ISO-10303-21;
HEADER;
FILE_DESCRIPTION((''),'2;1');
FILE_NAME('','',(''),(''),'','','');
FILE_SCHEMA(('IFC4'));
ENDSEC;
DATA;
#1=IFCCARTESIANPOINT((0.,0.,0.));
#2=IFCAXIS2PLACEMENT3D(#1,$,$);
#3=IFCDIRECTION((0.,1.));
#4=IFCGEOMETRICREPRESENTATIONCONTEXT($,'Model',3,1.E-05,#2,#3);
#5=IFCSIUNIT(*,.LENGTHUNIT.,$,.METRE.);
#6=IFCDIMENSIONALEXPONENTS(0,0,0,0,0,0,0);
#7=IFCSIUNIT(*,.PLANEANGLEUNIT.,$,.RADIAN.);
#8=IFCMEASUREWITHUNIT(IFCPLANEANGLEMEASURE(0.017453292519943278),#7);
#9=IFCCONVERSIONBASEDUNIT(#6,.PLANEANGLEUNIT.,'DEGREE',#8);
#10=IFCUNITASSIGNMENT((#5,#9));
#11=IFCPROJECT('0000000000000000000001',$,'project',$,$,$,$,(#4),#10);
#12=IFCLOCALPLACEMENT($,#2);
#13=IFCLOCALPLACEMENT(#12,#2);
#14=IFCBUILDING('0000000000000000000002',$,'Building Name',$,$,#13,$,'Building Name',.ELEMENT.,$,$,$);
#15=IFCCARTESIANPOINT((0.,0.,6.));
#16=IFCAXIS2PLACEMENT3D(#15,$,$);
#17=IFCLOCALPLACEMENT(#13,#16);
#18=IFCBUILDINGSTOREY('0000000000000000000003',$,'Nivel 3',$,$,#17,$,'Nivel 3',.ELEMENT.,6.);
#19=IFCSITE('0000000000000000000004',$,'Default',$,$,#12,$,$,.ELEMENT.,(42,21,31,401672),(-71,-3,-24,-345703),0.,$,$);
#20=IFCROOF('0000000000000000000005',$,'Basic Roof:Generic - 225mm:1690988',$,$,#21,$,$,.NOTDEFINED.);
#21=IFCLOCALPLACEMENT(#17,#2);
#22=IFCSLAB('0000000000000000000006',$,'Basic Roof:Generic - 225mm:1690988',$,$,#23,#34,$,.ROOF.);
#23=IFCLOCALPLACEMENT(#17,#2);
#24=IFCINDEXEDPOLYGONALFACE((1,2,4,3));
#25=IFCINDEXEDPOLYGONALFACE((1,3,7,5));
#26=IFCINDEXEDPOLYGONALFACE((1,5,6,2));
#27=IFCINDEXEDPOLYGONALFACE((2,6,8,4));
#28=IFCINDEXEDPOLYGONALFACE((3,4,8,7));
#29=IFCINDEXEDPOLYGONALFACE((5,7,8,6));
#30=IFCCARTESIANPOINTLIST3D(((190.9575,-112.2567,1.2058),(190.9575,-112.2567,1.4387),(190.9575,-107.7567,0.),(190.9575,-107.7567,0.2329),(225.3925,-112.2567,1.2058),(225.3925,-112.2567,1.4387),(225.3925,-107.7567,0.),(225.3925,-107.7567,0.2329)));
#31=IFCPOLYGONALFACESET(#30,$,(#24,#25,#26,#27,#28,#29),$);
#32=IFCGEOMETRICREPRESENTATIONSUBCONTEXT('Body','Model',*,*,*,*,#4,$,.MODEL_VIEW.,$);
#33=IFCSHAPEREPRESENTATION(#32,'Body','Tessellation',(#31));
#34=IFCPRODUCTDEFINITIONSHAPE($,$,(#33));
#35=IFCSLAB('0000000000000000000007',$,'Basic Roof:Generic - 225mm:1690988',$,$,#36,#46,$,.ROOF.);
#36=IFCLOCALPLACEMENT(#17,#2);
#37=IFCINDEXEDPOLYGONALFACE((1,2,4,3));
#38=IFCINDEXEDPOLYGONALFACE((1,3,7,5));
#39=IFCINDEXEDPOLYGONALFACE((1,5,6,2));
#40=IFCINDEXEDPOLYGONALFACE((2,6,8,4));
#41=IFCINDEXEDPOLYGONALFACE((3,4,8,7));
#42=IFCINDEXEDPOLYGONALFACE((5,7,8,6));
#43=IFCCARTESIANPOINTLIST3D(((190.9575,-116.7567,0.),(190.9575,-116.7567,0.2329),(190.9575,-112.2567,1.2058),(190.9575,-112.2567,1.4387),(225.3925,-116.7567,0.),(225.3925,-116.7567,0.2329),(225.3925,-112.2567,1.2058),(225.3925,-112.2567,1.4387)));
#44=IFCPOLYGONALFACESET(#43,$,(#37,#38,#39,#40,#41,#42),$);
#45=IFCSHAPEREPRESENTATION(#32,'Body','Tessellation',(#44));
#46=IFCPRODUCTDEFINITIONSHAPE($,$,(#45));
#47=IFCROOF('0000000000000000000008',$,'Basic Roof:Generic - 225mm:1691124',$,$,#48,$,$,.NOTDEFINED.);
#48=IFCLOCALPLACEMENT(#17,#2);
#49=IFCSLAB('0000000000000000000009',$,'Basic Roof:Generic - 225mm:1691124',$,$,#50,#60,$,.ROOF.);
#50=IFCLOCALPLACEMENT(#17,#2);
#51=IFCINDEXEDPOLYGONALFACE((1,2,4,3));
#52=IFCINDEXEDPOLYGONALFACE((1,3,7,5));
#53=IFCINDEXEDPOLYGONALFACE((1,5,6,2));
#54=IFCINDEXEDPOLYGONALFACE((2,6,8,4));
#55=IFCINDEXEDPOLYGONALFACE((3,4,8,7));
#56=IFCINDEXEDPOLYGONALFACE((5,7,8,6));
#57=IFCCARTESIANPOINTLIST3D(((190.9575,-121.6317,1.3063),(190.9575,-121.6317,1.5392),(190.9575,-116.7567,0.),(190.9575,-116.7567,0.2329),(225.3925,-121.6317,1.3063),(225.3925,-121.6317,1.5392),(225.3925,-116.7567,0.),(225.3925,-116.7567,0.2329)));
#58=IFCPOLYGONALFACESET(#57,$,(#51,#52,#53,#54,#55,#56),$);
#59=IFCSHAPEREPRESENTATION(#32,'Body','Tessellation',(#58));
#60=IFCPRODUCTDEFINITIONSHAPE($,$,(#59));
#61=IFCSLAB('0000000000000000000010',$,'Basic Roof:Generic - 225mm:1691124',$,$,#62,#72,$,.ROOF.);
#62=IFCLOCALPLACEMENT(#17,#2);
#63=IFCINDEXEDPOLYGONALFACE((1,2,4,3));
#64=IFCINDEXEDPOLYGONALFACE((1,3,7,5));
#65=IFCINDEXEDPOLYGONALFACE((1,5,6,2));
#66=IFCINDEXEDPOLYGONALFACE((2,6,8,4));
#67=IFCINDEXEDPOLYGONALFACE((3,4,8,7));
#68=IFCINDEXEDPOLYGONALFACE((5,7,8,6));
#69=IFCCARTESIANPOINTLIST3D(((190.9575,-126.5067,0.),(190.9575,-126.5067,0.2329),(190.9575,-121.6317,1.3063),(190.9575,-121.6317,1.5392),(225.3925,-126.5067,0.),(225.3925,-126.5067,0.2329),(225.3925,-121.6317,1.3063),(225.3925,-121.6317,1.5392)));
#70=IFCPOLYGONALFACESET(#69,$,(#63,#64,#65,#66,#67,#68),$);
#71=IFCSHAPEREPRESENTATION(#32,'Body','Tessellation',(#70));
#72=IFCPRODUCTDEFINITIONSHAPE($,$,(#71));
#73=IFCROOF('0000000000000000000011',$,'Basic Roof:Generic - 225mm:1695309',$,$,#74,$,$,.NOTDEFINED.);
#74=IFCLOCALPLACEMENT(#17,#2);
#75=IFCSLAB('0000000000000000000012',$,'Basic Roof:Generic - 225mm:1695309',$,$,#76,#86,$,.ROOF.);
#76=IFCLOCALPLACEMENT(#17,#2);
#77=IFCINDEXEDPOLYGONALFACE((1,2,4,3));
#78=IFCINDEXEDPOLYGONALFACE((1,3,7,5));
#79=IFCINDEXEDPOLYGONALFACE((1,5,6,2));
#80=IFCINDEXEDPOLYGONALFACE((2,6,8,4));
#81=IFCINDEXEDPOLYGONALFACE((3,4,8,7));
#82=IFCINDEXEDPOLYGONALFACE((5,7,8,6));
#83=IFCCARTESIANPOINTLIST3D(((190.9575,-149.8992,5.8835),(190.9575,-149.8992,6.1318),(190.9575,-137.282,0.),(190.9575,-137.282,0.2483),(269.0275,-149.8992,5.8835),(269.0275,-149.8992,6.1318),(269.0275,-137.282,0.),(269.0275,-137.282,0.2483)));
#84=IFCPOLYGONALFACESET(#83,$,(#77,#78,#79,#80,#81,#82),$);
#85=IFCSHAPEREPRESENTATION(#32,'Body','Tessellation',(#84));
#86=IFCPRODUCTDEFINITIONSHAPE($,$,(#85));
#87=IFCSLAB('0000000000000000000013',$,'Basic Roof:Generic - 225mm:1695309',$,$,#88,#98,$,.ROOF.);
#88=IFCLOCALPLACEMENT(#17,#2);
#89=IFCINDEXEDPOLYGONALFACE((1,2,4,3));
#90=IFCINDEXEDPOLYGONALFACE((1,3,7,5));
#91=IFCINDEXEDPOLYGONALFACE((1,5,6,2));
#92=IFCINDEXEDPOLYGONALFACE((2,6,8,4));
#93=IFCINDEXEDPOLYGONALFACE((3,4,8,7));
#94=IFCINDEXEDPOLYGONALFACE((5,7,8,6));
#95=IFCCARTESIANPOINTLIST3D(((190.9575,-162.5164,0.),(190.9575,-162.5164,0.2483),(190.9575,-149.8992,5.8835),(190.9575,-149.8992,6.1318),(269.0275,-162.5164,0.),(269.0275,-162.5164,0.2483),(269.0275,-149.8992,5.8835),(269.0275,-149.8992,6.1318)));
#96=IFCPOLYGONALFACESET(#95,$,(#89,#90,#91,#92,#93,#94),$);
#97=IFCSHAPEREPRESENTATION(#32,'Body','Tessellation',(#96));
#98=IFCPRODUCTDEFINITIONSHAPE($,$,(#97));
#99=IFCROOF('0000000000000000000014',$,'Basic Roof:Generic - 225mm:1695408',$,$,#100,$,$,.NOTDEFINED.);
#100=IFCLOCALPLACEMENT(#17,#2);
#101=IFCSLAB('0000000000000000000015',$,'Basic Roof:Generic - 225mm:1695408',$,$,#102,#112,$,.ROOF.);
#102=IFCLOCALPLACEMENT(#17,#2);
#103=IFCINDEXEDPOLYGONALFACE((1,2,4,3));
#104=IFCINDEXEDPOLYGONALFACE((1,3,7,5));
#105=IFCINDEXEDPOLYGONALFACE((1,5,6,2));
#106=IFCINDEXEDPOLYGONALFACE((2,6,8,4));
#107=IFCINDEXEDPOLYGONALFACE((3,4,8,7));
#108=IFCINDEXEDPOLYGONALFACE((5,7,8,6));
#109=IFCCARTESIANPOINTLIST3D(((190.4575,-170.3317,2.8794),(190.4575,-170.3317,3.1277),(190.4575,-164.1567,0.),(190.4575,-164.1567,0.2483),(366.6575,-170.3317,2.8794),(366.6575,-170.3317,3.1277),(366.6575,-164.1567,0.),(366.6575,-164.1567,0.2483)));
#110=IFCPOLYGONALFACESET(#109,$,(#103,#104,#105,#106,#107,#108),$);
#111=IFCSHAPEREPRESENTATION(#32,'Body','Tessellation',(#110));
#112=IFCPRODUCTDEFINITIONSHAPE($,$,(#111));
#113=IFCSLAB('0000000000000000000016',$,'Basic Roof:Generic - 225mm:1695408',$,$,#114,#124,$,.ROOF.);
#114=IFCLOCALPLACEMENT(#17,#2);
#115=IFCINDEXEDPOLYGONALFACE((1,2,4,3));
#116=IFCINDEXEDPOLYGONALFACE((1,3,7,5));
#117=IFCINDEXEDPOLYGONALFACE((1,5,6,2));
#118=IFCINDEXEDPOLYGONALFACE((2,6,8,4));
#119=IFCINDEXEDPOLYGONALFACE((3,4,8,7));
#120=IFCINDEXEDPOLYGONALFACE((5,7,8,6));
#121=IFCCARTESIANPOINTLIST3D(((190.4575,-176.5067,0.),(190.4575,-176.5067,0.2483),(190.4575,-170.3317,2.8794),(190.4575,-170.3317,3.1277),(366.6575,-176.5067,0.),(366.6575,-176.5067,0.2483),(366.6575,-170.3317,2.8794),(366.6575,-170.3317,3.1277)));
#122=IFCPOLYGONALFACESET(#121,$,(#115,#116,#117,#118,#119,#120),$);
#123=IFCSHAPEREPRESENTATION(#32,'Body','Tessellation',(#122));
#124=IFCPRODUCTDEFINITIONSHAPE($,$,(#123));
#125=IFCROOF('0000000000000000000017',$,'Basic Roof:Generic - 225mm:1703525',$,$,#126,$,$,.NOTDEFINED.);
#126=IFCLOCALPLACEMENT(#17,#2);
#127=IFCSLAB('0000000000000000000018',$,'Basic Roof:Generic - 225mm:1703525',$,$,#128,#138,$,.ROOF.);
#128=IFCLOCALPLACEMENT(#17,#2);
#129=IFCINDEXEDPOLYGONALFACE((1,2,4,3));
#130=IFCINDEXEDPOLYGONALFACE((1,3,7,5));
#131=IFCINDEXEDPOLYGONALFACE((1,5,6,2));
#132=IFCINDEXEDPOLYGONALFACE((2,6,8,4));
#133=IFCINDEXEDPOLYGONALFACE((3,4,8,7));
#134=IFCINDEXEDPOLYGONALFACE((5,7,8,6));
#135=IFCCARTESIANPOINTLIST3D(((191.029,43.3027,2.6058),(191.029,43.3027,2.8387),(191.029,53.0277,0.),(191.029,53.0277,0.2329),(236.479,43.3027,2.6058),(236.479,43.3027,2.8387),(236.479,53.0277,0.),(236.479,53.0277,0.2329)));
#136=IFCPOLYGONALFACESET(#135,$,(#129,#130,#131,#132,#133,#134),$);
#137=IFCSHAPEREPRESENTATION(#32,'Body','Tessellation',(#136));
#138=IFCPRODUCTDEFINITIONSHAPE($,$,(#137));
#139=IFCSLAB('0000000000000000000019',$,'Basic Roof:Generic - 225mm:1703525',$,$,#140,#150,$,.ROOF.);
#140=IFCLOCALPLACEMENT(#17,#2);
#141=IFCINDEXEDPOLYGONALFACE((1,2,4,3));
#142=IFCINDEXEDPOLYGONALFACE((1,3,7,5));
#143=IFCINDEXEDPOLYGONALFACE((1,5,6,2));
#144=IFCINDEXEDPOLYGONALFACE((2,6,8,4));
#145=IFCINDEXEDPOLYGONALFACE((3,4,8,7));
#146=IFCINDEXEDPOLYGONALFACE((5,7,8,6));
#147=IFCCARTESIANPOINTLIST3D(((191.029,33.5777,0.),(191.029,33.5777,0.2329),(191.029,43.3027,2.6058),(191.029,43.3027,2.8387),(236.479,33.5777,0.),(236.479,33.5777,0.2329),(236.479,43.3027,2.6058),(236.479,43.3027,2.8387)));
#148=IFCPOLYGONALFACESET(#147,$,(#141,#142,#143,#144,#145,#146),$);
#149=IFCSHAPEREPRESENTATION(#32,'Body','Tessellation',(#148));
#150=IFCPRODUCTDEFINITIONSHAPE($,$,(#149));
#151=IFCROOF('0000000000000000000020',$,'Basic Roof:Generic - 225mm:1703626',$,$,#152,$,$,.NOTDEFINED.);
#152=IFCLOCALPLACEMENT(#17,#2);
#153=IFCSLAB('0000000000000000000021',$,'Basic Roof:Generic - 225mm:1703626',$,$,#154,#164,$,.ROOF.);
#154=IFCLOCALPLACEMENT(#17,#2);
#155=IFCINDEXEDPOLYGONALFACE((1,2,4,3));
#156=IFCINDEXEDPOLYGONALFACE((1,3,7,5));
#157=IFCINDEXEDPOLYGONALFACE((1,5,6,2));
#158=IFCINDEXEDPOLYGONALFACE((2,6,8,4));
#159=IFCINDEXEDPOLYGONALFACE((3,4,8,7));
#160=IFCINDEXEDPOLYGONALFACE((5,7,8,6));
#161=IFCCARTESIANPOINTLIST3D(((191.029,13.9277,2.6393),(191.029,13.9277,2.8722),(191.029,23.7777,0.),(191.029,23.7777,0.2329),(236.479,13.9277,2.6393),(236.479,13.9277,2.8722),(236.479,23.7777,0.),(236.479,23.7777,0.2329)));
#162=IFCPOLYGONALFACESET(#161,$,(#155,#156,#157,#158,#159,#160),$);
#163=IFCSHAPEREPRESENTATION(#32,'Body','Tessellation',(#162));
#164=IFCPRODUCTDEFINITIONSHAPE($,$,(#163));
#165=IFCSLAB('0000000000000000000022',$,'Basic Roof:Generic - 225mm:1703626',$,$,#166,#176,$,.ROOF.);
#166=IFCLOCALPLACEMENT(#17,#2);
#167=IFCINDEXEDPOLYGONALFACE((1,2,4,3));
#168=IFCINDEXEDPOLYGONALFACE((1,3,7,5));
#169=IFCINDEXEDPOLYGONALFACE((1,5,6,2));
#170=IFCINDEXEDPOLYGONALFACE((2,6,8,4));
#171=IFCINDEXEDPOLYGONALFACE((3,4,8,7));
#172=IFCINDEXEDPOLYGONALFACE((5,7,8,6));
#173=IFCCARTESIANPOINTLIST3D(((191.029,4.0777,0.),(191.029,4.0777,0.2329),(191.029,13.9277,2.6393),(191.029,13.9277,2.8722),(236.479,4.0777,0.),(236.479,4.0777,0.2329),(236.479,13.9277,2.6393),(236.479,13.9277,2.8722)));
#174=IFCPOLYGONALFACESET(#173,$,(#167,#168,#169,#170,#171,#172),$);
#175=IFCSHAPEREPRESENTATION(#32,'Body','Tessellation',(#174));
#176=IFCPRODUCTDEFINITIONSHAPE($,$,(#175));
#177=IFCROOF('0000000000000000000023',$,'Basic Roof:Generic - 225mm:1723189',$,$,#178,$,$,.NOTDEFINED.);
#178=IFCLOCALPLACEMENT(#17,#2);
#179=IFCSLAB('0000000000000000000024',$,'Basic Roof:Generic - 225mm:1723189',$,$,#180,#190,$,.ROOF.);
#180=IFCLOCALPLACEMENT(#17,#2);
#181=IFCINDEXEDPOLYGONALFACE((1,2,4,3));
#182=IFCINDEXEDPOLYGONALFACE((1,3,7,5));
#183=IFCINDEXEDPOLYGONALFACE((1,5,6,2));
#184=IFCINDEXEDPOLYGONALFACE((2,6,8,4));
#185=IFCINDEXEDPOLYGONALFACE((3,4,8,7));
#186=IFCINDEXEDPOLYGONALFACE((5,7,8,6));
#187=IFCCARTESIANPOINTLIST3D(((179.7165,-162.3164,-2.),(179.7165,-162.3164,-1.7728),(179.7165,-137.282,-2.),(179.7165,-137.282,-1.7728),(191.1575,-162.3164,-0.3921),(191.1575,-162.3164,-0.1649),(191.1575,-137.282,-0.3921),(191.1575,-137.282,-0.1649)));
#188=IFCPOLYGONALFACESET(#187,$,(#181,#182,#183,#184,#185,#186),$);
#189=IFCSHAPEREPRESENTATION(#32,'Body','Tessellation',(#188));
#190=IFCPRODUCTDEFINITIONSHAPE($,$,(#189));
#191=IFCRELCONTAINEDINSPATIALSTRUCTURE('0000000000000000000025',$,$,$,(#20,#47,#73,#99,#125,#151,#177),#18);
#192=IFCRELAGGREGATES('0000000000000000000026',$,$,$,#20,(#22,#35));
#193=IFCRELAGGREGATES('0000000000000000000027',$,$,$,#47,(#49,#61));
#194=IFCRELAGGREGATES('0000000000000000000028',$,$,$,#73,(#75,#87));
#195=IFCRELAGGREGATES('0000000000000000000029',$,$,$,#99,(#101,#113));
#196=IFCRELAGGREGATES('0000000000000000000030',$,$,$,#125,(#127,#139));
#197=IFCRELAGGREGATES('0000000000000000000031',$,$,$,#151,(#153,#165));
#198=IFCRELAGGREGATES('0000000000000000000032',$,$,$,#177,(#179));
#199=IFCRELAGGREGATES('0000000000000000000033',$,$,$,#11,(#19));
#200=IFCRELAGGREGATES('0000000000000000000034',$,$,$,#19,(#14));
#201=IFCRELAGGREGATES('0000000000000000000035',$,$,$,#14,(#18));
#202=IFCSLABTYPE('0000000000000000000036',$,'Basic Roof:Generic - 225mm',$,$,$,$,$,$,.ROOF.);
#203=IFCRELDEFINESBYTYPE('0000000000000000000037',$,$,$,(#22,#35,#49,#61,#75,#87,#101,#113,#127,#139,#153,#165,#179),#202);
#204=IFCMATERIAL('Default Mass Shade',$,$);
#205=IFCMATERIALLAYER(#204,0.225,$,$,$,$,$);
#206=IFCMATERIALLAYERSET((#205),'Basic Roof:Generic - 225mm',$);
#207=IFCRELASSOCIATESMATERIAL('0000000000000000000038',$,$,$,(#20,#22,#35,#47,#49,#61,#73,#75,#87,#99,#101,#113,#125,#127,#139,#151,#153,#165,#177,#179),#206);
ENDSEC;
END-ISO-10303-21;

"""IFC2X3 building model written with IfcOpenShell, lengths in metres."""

from ifc_helpers import new_model, entity, si_unit, converted_unit, direction, frame, frame_2d, origin, place, context, subcontext, project, spatial, rectangle, extrude, material, layer, layer_set, type_object, element, aggregate, save


model = new_model("IFC2X3")

# Units and contexts
model_context = context("Model", 3, precision=1e-05, world=origin(), true_north=direction((0.0, 1.0)))
body_context = subcontext(model_context, "Body", "Model", "MODEL_VIEW")
ifc_project = project(units=[si_unit("LENGTHUNIT", "METRE"), converted_unit("PLANEANGLEUNIT", "DEGREE", entity("IfcPlaneAngleMeasure", 0.017453292519943278), si_unit("PLANEANGLEUNIT", "RADIAN"), dimensions=[0, 0, 0, 0, 0, 0, 0])], contexts=[model_context])

# Site, building, storey
site_placement = place(None, origin())
site = spatial("IfcSite", under=ifc_project, at=site_placement, Name="Default", CompositionType="ELEMENT", RefLatitude=(42, 21, 31, 401672), RefLongitude=(-71, -3, -24, -345703), RefElevation=0.0)
building_placement = place(site_placement, origin())
building = spatial("IfcBuilding", under=site, at=building_placement, Name="Building Name", LongName="Building Name", CompositionType="ELEMENT")
storey_placement = place(building_placement, frame((0.0, 0.0, 6.0)))
storey = spatial("IfcBuildingStorey", under=building, at=storey_placement, Name="Nivel 3", LongName="Nivel 3", CompositionType="ELEMENT", Elevation=6.0)

# Roofs, slabs
ifc_material_1 = material(Name="Default Mass Shade")
ifc_layer_1 = layer(ifc_material_1, 0.225)
ifc_layer_set_1 = layer_set([ifc_layer_1], Name="Basic Roof:Generic - 225mm")
slab_type = type_object("IfcSlabType", Name="Basic Roof:Generic - 225mm", PredefinedType="ROOF")
roof_1_placement = place(storey_placement, frame((190.9575, -116.7567, 0.0)))
roof_1 = element("IfcRoof", 1, at=roof_1_placement, inside=storey, material=ifc_layer_set_1, Name="Basic Roof:Generic - 225mm:1690988", ShapeType="NOTDEFINED")
slab_1_placement = place(roof_1_placement, origin())
slab_1 = element("IfcSlab", 2, at=slab_1_placement, type_object=slab_type, material=ifc_layer_set_1, Name="Basic Roof:Generic - 225mm:1690988", PredefinedType="ROOF", context=body_context, shape_type="SweptSolid", body=[
    extrude(rectangle(XDim=4.6587, YDim=34.435, at=frame_2d((0.0, 0.0), x_axis=(0.0, -1.0))), frame((17.2175, 6.75, 0.6029), z_axis=(0.0, 0.258819, 0.965926), x_axis=(1.0, 0.0, 0.0)), (0.0, -0.258819, 0.965926), 0.2329),
])
slab_2_placement = place(roof_1_placement, origin())
slab_2 = element("IfcSlab", 3, at=slab_2_placement, type_object=slab_type, material=ifc_layer_set_1, Name="Basic Roof:Generic - 225mm:1690988", PredefinedType="ROOF", context=body_context, shape_type="SweptSolid", body=[
    extrude(rectangle(XDim=34.435, YDim=4.6587, at=frame_2d((0.0, 0.0), x_axis=(-1.0, 0.0))), frame((17.2175, 2.25, 0.6029), z_axis=(0.0, -0.258819, 0.965926), x_axis=(1.0, 0.0, 0.0)), (0.0, 0.258819, 0.965926), 0.2329),
])
aggregate(roof_1, [slab_1, slab_2])
roof_2_placement = place(storey_placement, frame((190.9575, -126.5067, 0.0)))
roof_2 = element("IfcRoof", 4, at=roof_2_placement, inside=storey, material=ifc_layer_set_1, Name="Basic Roof:Generic - 225mm:1691124", ShapeType="NOTDEFINED")
slab_3_placement = place(roof_2_placement, origin())
slab_3 = element("IfcSlab", 5, at=slab_3_placement, type_object=slab_type, material=ifc_layer_set_1, Name="Basic Roof:Generic - 225mm:1691124", PredefinedType="ROOF", context=body_context, shape_type="SweptSolid", body=[
    extrude(rectangle(XDim=5.047, YDim=34.435, at=frame_2d((0.0, 0.0), x_axis=(0.0, -1.0))), frame((17.2175, 7.3125, 0.6531), z_axis=(0.0, 0.258819, 0.965926), x_axis=(1.0, 0.0, 0.0)), (0.0, -0.258819, 0.965926), 0.2329),
])
slab_4_placement = place(roof_2_placement, origin())
slab_4 = element("IfcSlab", 6, at=slab_4_placement, type_object=slab_type, material=ifc_layer_set_1, Name="Basic Roof:Generic - 225mm:1691124", PredefinedType="ROOF", context=body_context, shape_type="SweptSolid", body=[
    extrude(rectangle(XDim=34.435, YDim=5.047, at=frame_2d((0.0, 0.0), x_axis=(-1.0, 0.0))), frame((17.2175, 2.4375, 0.6531), z_axis=(0.0, -0.258819, 0.965926), x_axis=(1.0, 0.0, 0.0)), (0.0, 0.258819, 0.965926), 0.2329),
])
aggregate(roof_2, [slab_3, slab_4])
roof_3_placement = place(storey_placement, frame((190.9575, -162.5164, 0.0)))
roof_3 = element("IfcRoof", 7, at=roof_3_placement, inside=storey, material=ifc_layer_set_1, Name="Basic Roof:Generic - 225mm:1695309", ShapeType="NOTDEFINED")
slab_5_placement = place(roof_3_placement, origin())
slab_5 = element("IfcSlab", 8, at=slab_5_placement, type_object=slab_type, material=ifc_layer_set_1, Name="Basic Roof:Generic - 225mm:1695309", PredefinedType="ROOF", context=body_context, shape_type="SweptSolid", body=[
    extrude(rectangle(XDim=78.07, YDim=13.9216, at=frame_2d((0.0, 0.0), x_axis=(1.0, 0.0))), frame((39.035, 18.9258, 2.9418), z_axis=(0.0, 0.422618, 0.906308), x_axis=(1.0, 0.0, 0.0)), (0.0, -0.422618, 0.906308), 0.2483),
])
slab_6_placement = place(roof_3_placement, origin())
slab_6 = element("IfcSlab", 9, at=slab_6_placement, type_object=slab_type, material=ifc_layer_set_1, Name="Basic Roof:Generic - 225mm:1695309", PredefinedType="ROOF", context=body_context, shape_type="SweptSolid", body=[
    extrude(rectangle(XDim=13.9216, YDim=78.07, at=frame_2d((0.0, 0.0), x_axis=(0.0, 1.0))), frame((39.035, 6.3086, 2.9418), z_axis=(0.0, -0.422618, 0.906308), x_axis=(1.0, 0.0, 0.0)), (0.0, 0.422618, 0.906308), 0.2483),
])
aggregate(roof_3, [slab_5, slab_6])
roof_4_placement = place(storey_placement, frame((190.4575, -176.5067, 0.0)))
roof_4 = element("IfcRoof", 10, at=roof_4_placement, inside=storey, material=ifc_layer_set_1, Name="Basic Roof:Generic - 225mm:1695408", ShapeType="NOTDEFINED")
slab_7_placement = place(roof_4_placement, origin())
slab_7 = element("IfcSlab", 11, at=slab_7_placement, type_object=slab_type, material=ifc_layer_set_1, Name="Basic Roof:Generic - 225mm:1695408", PredefinedType="ROOF", context=body_context, shape_type="SweptSolid", body=[
    extrude(rectangle(XDim=6.8134, YDim=176.2, at=frame_2d((0.0, 0.0), x_axis=(0.0, -1.0))), frame((88.1, 9.2625, 1.4397), z_axis=(0.0, 0.422618, 0.906308), x_axis=(1.0, 0.0, 0.0)), (0.0, -0.422618, 0.906308), 0.2483),
])
slab_8_placement = place(roof_4_placement, origin())
slab_8 = element("IfcSlab", 12, at=slab_8_placement, type_object=slab_type, material=ifc_layer_set_1, Name="Basic Roof:Generic - 225mm:1695408", PredefinedType="ROOF", context=body_context, shape_type="SweptSolid", body=[
    extrude(rectangle(XDim=176.2, YDim=6.8134, at=frame_2d((0.0, 0.0), x_axis=(-1.0, 0.0))), frame((88.1, 3.0875, 1.4397), z_axis=(0.0, -0.422618, 0.906308), x_axis=(1.0, 0.0, 0.0)), (0.0, 0.422618, 0.906308), 0.2483),
])
aggregate(roof_4, [slab_7, slab_8])
roof_5_placement = place(storey_placement, frame((191.029, 33.5777, 0.0)))
roof_5 = element("IfcRoof", 13, at=roof_5_placement, inside=storey, material=ifc_layer_set_1, Name="Basic Roof:Generic - 225mm:1703525", ShapeType="NOTDEFINED")
slab_9_placement = place(roof_5_placement, origin())
slab_9 = element("IfcSlab", 14, at=slab_9_placement, type_object=slab_type, material=ifc_layer_set_1, Name="Basic Roof:Generic - 225mm:1703525", PredefinedType="ROOF", context=body_context, shape_type="SweptSolid", body=[
    extrude(rectangle(XDim=10.0681, YDim=45.45, at=frame_2d((0.0, 0.0), x_axis=(0.0, -1.0))), frame((22.725, 14.5875, 1.3029), z_axis=(0.0, 0.258819, 0.965926), x_axis=(1.0, 0.0, 0.0)), (0.0, -0.258819, 0.965926), 0.2329),
])
slab_10_placement = place(roof_5_placement, origin())
slab_10 = element("IfcSlab", 15, at=slab_10_placement, type_object=slab_type, material=ifc_layer_set_1, Name="Basic Roof:Generic - 225mm:1703525", PredefinedType="ROOF", context=body_context, shape_type="SweptSolid", body=[
    extrude(rectangle(XDim=45.45, YDim=10.0681, at=frame_2d((0.0, 0.0), x_axis=(-1.0, 0.0))), frame((22.725, 4.8625, 1.3029), z_axis=(0.0, -0.258819, 0.965926), x_axis=(1.0, 0.0, 0.0)), (0.0, 0.258819, 0.965926), 0.2329),
])
aggregate(roof_5, [slab_9, slab_10])
roof_6_placement = place(storey_placement, frame((191.029, 4.0777, 0.0)))
roof_6 = element("IfcRoof", 16, at=roof_6_placement, inside=storey, material=ifc_layer_set_1, Name="Basic Roof:Generic - 225mm:1703626", ShapeType="NOTDEFINED")
slab_11_placement = place(roof_6_placement, origin())
slab_11 = element("IfcSlab", 17, at=slab_11_placement, type_object=slab_type, material=ifc_layer_set_1, Name="Basic Roof:Generic - 225mm:1703626", PredefinedType="ROOF", context=body_context, shape_type="SweptSolid", body=[
    extrude(rectangle(XDim=10.1975, YDim=45.45, at=frame_2d((0.0, 0.0), x_axis=(0.0, -1.0))), frame((22.725, 14.775, 1.3196), z_axis=(0.0, 0.258819, 0.965926), x_axis=(1.0, 0.0, 0.0)), (0.0, -0.258819, 0.965926), 0.2329),
])
slab_12_placement = place(roof_6_placement, origin())
slab_12 = element("IfcSlab", 18, at=slab_12_placement, type_object=slab_type, material=ifc_layer_set_1, Name="Basic Roof:Generic - 225mm:1703626", PredefinedType="ROOF", context=body_context, shape_type="SweptSolid", body=[
    extrude(rectangle(XDim=45.45, YDim=10.1975, at=frame_2d((0.0, 0.0), x_axis=(-1.0, 0.0))), frame((22.725, 4.925, 1.3196), z_axis=(0.0, -0.258819, 0.965926), x_axis=(1.0, 0.0, 0.0)), (0.0, 0.258819, 0.965926), 0.2329),
])
aggregate(roof_6, [slab_11, slab_12])

# Roof, slab
roof_7_placement = place(storey_placement, frame((179.7165, -162.3164, -2.0)))
roof_7 = element("IfcRoof", 19, at=roof_7_placement, inside=storey, material=ifc_layer_set_1, Name="Basic Roof:Generic - 225mm:1723189", ShapeType="NOTDEFINED")
slab_13_placement = place(roof_7_placement, origin())
slab_13 = element("IfcSlab", 20, at=slab_13_placement, type_object=slab_type, material=ifc_layer_set_1, Name="Basic Roof:Generic - 225mm:1723189", PredefinedType="ROOF", context=body_context, shape_type="SweptSolid", body=[
    extrude(rectangle(XDim=11.5535, YDim=25.0344, at=frame_2d((0.0, 0.0), x_axis=(1.0, 0.0))), frame((5.7205, 12.5172, 0.804), z_axis=(-0.139173, 0.0, 0.990268), x_axis=(0.990268, 0.0, 0.139173)), (0.139173, 0.0, 0.990268), 0.2272),
])
aggregate(roof_7, [slab_13])

save(model, "model.ifc")
